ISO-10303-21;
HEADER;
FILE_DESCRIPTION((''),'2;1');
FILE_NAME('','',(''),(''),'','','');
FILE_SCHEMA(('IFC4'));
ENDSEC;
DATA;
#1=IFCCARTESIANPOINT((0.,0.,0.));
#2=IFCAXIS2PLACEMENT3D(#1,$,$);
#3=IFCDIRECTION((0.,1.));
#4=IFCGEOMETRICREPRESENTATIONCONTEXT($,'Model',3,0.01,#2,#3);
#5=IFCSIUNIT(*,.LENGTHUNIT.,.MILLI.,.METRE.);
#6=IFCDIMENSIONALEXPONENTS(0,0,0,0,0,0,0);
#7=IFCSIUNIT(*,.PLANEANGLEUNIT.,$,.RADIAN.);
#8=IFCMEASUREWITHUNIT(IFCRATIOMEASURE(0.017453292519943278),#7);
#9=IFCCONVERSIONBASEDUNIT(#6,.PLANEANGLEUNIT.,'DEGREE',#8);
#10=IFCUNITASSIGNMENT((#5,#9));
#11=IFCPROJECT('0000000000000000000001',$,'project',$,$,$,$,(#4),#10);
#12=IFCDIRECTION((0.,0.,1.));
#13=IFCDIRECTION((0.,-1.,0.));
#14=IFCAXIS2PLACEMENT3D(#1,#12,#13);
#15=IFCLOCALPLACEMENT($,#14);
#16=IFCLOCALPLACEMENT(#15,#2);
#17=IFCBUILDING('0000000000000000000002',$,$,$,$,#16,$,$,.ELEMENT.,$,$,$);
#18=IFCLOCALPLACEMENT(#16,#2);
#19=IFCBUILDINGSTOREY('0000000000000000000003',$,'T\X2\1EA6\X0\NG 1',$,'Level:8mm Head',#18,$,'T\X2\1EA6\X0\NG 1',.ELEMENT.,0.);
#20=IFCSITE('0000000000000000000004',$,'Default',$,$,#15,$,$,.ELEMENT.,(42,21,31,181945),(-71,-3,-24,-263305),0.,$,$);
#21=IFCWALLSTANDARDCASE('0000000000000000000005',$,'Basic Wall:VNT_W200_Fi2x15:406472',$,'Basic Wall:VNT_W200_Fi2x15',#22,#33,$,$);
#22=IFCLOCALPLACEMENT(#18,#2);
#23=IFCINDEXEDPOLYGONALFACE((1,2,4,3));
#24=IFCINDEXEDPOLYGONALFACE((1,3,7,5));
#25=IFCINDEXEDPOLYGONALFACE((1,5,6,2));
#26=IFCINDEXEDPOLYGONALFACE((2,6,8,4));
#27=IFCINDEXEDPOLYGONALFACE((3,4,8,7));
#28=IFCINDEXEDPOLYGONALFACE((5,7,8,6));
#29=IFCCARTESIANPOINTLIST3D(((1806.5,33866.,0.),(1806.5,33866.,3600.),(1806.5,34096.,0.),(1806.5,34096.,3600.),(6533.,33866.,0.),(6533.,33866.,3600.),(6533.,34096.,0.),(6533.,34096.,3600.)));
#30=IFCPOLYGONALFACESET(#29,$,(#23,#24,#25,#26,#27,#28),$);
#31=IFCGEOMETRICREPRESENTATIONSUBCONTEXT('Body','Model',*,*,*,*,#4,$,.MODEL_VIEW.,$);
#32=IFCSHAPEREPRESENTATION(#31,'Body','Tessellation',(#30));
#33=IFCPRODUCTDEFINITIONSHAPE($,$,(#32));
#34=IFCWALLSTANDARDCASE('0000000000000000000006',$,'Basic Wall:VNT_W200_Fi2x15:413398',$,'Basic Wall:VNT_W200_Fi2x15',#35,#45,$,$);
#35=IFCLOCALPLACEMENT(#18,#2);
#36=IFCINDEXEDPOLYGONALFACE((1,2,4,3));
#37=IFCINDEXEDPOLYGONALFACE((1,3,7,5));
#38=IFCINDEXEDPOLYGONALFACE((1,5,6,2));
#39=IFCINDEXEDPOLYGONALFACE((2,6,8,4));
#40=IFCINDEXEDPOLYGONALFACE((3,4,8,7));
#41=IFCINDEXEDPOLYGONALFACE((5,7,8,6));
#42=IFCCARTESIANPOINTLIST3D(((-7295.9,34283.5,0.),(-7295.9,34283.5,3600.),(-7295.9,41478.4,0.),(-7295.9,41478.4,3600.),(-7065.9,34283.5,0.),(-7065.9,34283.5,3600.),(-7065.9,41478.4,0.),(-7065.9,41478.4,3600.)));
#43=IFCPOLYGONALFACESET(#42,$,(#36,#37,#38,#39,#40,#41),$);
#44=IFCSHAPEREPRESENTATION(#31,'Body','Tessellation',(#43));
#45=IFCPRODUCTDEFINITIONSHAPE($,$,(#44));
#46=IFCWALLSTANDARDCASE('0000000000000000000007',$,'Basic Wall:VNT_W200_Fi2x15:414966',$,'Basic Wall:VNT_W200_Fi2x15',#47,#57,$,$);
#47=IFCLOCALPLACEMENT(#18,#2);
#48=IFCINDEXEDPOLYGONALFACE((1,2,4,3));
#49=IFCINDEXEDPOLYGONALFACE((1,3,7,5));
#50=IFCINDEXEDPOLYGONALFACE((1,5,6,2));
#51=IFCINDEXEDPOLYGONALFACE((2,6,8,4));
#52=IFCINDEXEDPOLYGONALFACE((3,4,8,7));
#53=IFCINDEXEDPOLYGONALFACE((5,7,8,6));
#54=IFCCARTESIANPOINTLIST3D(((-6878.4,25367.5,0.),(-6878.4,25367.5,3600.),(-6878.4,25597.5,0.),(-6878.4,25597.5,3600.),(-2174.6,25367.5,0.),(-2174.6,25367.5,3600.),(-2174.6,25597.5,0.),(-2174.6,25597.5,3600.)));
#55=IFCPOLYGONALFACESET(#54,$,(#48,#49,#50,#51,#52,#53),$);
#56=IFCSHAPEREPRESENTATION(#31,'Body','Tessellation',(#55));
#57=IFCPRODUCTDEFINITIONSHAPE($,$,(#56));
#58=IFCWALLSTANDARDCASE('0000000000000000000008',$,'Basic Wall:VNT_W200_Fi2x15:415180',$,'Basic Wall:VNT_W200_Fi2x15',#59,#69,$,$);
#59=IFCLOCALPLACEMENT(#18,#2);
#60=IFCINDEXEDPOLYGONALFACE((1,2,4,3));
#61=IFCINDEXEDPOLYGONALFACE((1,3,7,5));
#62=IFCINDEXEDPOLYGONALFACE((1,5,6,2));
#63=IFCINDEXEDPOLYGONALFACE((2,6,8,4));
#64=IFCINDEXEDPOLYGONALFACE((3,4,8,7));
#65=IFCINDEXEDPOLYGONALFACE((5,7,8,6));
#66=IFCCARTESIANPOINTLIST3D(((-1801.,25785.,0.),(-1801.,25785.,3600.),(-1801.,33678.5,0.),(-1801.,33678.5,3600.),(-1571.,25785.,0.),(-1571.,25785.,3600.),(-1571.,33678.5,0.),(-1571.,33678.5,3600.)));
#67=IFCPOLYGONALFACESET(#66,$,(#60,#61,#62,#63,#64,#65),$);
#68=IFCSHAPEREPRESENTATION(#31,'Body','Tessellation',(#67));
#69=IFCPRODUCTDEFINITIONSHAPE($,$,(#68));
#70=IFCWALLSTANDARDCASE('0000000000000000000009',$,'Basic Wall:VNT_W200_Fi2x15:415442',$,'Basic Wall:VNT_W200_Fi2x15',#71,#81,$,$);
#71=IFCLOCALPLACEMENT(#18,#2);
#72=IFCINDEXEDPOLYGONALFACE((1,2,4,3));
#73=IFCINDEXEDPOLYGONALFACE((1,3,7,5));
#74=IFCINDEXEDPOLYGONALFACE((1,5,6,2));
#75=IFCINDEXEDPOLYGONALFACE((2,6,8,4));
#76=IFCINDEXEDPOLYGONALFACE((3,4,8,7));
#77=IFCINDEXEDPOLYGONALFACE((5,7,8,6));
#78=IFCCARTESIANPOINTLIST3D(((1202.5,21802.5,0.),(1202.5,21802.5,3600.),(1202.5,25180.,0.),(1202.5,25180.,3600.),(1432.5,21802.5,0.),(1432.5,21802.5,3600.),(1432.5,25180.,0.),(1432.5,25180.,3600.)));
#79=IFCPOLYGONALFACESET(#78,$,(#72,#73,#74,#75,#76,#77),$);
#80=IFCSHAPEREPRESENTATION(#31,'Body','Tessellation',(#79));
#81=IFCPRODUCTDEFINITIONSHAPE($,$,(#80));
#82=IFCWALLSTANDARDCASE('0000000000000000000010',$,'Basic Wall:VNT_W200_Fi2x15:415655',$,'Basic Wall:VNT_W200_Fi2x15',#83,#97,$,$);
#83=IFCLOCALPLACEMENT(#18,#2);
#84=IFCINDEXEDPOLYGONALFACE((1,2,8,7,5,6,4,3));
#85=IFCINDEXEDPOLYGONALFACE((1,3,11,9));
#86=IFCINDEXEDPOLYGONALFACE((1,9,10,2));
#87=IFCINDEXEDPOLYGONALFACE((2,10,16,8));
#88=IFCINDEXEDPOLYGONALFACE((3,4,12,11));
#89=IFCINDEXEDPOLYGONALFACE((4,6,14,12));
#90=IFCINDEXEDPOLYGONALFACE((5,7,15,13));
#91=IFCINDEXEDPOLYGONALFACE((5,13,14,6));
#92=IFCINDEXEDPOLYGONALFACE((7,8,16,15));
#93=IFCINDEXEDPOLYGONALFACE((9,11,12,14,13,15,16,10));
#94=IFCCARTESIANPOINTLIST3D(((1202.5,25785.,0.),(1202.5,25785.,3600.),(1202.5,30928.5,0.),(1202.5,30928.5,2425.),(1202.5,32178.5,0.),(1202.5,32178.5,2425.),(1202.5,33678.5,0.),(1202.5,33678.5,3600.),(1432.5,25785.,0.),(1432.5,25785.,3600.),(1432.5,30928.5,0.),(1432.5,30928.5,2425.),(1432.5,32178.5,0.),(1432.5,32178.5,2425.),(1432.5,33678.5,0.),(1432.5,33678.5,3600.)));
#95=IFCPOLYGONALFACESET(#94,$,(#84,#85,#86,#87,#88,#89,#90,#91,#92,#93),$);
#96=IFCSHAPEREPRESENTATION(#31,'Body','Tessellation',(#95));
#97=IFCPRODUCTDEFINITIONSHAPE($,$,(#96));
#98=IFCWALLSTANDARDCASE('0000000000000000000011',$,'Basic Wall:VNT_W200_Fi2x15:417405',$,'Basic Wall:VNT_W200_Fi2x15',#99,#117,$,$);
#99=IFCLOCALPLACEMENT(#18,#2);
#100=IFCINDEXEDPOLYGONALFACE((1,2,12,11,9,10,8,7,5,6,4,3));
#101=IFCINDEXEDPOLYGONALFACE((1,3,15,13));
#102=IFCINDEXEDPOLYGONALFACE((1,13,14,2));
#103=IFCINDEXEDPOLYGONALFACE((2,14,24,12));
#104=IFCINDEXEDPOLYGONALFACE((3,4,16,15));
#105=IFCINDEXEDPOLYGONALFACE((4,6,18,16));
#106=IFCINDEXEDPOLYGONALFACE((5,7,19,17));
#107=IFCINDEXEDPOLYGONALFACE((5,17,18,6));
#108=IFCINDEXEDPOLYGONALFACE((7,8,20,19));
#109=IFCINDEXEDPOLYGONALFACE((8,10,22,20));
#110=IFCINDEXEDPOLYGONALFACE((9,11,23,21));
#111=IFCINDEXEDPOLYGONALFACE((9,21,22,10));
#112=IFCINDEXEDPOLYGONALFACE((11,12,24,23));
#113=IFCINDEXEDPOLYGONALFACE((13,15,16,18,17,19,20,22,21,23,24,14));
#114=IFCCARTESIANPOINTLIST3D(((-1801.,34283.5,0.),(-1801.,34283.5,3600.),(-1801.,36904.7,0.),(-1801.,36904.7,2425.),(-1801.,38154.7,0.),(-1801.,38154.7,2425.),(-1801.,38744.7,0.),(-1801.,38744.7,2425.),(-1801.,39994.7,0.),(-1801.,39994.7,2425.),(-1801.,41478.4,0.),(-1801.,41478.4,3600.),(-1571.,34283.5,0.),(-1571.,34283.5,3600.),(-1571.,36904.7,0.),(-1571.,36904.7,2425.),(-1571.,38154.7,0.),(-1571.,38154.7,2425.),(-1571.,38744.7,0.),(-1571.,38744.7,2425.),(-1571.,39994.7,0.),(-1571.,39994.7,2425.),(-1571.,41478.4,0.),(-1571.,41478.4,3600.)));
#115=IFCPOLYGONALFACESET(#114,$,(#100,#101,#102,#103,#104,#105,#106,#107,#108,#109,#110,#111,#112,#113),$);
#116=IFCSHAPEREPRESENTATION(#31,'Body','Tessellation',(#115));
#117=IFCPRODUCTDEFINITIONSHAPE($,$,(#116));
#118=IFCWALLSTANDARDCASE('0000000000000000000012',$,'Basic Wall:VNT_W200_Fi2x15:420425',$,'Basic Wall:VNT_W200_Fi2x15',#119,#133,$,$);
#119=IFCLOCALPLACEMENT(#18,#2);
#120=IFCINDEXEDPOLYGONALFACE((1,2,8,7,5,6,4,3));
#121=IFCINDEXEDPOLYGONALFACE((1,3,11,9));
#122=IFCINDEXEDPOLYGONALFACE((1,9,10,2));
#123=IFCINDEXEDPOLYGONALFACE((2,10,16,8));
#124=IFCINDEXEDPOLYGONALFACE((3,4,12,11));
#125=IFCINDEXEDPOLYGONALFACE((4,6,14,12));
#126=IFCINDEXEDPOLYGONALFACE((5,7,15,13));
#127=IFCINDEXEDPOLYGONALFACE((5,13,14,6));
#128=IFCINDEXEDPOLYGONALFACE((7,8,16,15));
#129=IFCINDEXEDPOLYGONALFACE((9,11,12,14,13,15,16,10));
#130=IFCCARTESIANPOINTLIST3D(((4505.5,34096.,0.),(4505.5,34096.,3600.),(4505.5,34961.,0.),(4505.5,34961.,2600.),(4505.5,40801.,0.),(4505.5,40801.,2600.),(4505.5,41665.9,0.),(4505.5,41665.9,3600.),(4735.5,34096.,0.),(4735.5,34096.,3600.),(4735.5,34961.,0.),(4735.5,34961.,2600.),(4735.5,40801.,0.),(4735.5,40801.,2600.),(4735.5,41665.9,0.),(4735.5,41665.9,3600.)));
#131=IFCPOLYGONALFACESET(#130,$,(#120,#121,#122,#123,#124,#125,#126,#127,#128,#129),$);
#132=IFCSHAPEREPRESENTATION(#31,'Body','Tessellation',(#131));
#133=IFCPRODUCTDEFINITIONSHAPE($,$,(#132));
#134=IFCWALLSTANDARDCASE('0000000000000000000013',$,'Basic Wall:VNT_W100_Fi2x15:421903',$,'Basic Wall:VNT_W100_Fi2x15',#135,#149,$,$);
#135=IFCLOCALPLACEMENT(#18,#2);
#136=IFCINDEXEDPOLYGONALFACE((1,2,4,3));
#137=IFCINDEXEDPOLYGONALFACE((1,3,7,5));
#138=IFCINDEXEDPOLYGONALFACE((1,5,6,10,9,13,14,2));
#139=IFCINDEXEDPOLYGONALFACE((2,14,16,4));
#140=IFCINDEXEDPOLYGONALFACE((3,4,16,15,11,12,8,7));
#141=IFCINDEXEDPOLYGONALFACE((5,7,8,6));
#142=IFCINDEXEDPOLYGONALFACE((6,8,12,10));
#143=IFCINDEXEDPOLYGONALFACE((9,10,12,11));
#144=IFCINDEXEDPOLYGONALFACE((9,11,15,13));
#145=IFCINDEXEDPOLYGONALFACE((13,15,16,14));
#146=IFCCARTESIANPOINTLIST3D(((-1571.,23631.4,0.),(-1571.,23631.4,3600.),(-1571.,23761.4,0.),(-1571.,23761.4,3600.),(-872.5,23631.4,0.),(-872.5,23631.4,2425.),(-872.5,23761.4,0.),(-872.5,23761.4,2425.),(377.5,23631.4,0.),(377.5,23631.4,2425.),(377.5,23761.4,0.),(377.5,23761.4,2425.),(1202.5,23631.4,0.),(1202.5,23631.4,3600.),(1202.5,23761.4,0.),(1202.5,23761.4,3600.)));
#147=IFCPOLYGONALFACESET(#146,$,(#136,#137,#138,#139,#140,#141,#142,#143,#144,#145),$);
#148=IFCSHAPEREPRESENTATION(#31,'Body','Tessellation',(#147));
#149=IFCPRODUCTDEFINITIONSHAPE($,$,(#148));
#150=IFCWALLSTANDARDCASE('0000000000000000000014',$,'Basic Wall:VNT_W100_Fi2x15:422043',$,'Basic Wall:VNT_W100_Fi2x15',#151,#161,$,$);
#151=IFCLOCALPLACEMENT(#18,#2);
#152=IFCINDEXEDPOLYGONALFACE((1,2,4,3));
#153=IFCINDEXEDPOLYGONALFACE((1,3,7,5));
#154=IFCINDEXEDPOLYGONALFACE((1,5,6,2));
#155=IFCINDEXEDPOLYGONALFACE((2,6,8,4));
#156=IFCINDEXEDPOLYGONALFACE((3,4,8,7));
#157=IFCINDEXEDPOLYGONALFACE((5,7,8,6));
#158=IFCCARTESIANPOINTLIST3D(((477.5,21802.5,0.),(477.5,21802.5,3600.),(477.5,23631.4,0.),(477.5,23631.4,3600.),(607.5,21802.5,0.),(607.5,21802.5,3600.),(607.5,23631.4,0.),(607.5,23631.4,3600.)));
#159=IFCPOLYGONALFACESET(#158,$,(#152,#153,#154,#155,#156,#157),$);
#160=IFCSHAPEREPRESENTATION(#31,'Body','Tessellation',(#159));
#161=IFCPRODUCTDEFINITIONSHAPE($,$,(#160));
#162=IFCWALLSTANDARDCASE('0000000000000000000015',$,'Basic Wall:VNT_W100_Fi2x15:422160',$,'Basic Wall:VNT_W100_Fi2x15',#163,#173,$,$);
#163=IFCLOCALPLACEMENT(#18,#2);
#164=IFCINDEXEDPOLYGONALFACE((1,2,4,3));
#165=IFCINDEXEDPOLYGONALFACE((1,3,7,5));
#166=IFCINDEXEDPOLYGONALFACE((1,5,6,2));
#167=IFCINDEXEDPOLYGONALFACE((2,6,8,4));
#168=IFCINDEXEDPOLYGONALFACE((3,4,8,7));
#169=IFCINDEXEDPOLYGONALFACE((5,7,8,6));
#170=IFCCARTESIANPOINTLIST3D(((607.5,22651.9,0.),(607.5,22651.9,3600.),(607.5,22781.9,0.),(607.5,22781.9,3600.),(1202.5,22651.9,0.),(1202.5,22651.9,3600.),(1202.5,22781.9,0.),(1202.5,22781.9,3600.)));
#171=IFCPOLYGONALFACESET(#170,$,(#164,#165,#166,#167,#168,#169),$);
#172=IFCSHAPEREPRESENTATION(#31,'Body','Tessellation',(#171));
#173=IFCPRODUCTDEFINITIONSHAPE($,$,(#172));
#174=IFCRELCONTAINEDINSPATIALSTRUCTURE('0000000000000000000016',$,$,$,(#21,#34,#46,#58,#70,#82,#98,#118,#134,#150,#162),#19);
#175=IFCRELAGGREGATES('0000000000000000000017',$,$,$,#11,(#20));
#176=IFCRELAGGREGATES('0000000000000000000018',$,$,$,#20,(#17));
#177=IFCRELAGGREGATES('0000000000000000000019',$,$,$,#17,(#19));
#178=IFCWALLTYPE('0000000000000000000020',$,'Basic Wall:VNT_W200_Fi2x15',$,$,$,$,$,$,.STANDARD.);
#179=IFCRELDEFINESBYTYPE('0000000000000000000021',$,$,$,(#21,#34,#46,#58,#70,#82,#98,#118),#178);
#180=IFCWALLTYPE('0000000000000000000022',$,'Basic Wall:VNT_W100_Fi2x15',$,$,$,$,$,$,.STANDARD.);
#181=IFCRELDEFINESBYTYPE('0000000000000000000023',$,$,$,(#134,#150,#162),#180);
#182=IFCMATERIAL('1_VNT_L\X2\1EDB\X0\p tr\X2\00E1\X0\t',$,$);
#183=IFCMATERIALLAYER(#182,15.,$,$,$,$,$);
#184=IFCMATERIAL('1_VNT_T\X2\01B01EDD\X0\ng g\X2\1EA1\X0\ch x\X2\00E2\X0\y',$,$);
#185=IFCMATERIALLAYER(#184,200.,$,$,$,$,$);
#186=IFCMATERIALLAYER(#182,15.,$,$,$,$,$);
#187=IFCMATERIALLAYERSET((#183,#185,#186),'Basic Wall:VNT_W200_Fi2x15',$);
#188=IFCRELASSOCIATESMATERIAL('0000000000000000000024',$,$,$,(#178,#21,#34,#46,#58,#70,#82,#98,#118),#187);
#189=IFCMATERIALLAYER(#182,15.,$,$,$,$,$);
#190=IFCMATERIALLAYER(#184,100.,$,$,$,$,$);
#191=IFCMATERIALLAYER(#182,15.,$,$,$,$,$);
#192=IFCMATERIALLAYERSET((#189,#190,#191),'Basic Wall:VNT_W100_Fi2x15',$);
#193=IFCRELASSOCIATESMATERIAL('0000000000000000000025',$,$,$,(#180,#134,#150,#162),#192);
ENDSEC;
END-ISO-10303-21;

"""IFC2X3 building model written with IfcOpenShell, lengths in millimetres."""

from ifc_helpers import new_model, entity, si_unit, converted_unit, direction, frame, frame_2d, origin, place, context, subcontext, project, spatial, rectangle, extrude, material, layer, layer_set, layer_usage, type_object, element, save


model = new_model("IFC2X3")

# Units and contexts
model_context = context("Model", 3, precision=0.01, world=origin(), true_north=direction((0.0, 1.0)))
body_context = subcontext(model_context, "Body", "Model", "MODEL_VIEW")
ifc_project = project(units=[si_unit("LENGTHUNIT", "METRE", prefix="MILLI"), converted_unit("PLANEANGLEUNIT", "DEGREE", entity("IfcRatioMeasure", 0.017453292519943278), si_unit("PLANEANGLEUNIT", "RADIAN"), dimensions=[0, 0, 0, 0, 0, 0, 0])], contexts=[model_context])

# Site, building, storey
site_placement = place(None, frame((0.0, 0.0, 0.0), z_axis=(0.0, 0.0, 1.0), x_axis=(0.0, -1.0, 0.0)))
site = spatial("IfcSite", under=ifc_project, at=site_placement, Name="Default", CompositionType="ELEMENT", RefLatitude=(42, 21, 31, 181945), RefLongitude=(-71, -3, -24, -263305), RefElevation=0.0)
building_placement = place(site_placement, origin())
building = spatial("IfcBuilding", under=site, at=building_placement, CompositionType="ELEMENT")
storey_placement = place(building_placement, origin())
storey = spatial("IfcBuildingStorey", under=building, at=storey_placement, Name="TẦNG 1", ObjectType="Level:8mm Head", LongName="TẦNG 1", CompositionType="ELEMENT", Elevation=0.0)

# Walls
ifc_material_1 = material(Name="1_VNT_Lớp trát")
ifc_layer_1 = layer(ifc_material_1, 15.0)
ifc_material_2 = material(Name="1_VNT_Tường gạch xây")
ifc_layer_2 = layer(ifc_material_2, 200.0)
ifc_layer_3 = layer(ifc_material_1, 15.0)
ifc_layer_set_1 = layer_set([ifc_layer_1, ifc_layer_2, ifc_layer_3], Name="Basic Wall:VNT_W200_Fi2x15")
ifc_layer_usage_1 = layer_usage(ifc_layer_set_1, "AXIS2", "NEGATIVE", 115.0)
wall_type_1 = type_object("IfcWallType", Name="Basic Wall:VNT_W200_Fi2x15", PredefinedType="STANDARD", material=ifc_layer_set_1)
wall_1_placement = place(storey_placement, frame((6533.0, 33981.0, 0.0), z_axis=(0.0, 0.0, 1.0), x_axis=(-1.0, 0.0, 0.0)))
element("IfcWallStandardCase", 1, at=wall_1_placement, inside=storey, type_object=wall_type_1, material=ifc_layer_usage_1, Name="Basic Wall:VNT_W200_Fi2x15:406472", ObjectType="Basic Wall:VNT_W200_Fi2x15", context=body_context, shape_type="SweptSolid", body=[
    extrude(rectangle(XDim=4726.6, YDim=230.0, at=frame_2d((2363.3, 0.0), x_axis=(-1.0, 0.0))), origin(), (0.0, 0.0, 1.0), 3600.0),
])
wall_2_placement = place(storey_placement, frame((-7180.9, 34283.5, 0.0), z_axis=(0.0, 0.0, 1.0), x_axis=(0.0, 1.0, 0.0)))
element("IfcWallStandardCase", 2, at=wall_2_placement, inside=storey, type_object=wall_type_1, material=ifc_layer_usage_1, Name="Basic Wall:VNT_W200_Fi2x15:413398", ObjectType="Basic Wall:VNT_W200_Fi2x15", context=body_context, shape_type="SweptSolid", body=[
    extrude(rectangle(XDim=7195.0, YDim=230.0, at=frame_2d((3597.5, 0.0), x_axis=(-1.0, 0.0))), origin(), (0.0, 0.0, 1.0), 3600.0),
])
wall_3_placement = place(storey_placement, frame((-6878.4, 25482.5, 0.0)))
element("IfcWallStandardCase", 3, at=wall_3_placement, inside=storey, type_object=wall_type_1, material=ifc_layer_usage_1, Name="Basic Wall:VNT_W200_Fi2x15:414966", ObjectType="Basic Wall:VNT_W200_Fi2x15", context=body_context, shape_type="SweptSolid", body=[
    extrude(rectangle(XDim=4703.8, YDim=230.0, at=frame_2d((2351.9, 0.0), x_axis=(-1.0, 0.0))), origin(), (0.0, 0.0, 1.0), 3600.0),
])
wall_4_placement = place(storey_placement, frame((-1686.0, 25785.0, 0.0), z_axis=(0.0, 0.0, 1.0), x_axis=(0.0, 1.0, 0.0)))
element("IfcWallStandardCase", 4, at=wall_4_placement, inside=storey, type_object=wall_type_1, material=ifc_layer_usage_1, Name="Basic Wall:VNT_W200_Fi2x15:415180", ObjectType="Basic Wall:VNT_W200_Fi2x15", context=body_context, shape_type="SweptSolid", body=[
    extrude(rectangle(XDim=7893.5, YDim=230.0, at=frame_2d((3946.7, 0.0), x_axis=(-1.0, 0.0))), origin(), (0.0, 0.0, 1.0), 3600.0),
])
wall_5_placement = place(storey_placement, frame((1317.5, 21802.5, 0.0), z_axis=(0.0, 0.0, 1.0), x_axis=(0.0, 1.0, 0.0)))
element("IfcWallStandardCase", 5, at=wall_5_placement, inside=storey, type_object=wall_type_1, material=ifc_layer_usage_1, Name="Basic Wall:VNT_W200_Fi2x15:415442", ObjectType="Basic Wall:VNT_W200_Fi2x15", context=body_context, shape_type="SweptSolid", body=[
    extrude(rectangle(XDim=3377.5, YDim=230.0, at=frame_2d((1688.8, 0.0), x_axis=(-1.0, 0.0))), origin(), (0.0, 0.0, 1.0), 3600.0),
])

# Wall, opening
wall_6_placement = place(storey_placement, frame((1317.5, 25785.0, 0.0), z_axis=(0.0, 0.0, 1.0), x_axis=(0.0, 1.0, 0.0)))
wall_6 = element("IfcWallStandardCase", 6, at=wall_6_placement, inside=storey, type_object=wall_type_1, material=ifc_layer_usage_1, Name="Basic Wall:VNT_W200_Fi2x15:415655", ObjectType="Basic Wall:VNT_W200_Fi2x15", context=body_context, shape_type="SweptSolid", body=[
    extrude(rectangle(XDim=7893.5, YDim=230.0, at=frame_2d((3946.7, 0.0), x_axis=(-1.0, 0.0))), origin(), (0.0, 0.0, 1.0), 3600.0),
])
opening_1_placement = place(wall_6_placement, frame((6393.5, 115.0, 0.0)))
element("IfcOpeningElement", 7, at=opening_1_placement, cuts=wall_6, ObjectType="Opening", context=body_context, shape_type="SweptSolid", body=[
    extrude(rectangle(XDim=2425.0, YDim=1250.0, at=frame_2d((1212.5, 625.0), x_axis=(1.0, 0.0))), frame((0.0, 0.0, 0.0), z_axis=(0.0, -1.0, 0.0), x_axis=(0.0, 0.0, 1.0)), (0.0, 0.0, 1.0), 230.0),
])

# Wall, openings
wall_7_placement = place(storey_placement, frame((-1686.0, 34283.5, 0.0), z_axis=(0.0, 0.0, 1.0), x_axis=(0.0, 1.0, 0.0)))
wall_7 = element("IfcWallStandardCase", 8, at=wall_7_placement, inside=storey, type_object=wall_type_1, material=ifc_layer_usage_1, Name="Basic Wall:VNT_W200_Fi2x15:417405", ObjectType="Basic Wall:VNT_W200_Fi2x15", context=body_context, shape_type="SweptSolid", body=[
    extrude(rectangle(XDim=7195.0, YDim=230.0, at=frame_2d((3597.5, 0.0), x_axis=(-1.0, 0.0))), origin(), (0.0, 0.0, 1.0), 3600.0),
])
opening_2_placement = place(wall_7_placement, frame((2621.2, -115.0, 0.0)))
element("IfcOpeningElement", 9, at=opening_2_placement, cuts=wall_7, ObjectType="Opening", context=body_context, shape_type="SweptSolid", body=[
    extrude(rectangle(XDim=2425.0, YDim=1250.0, at=frame_2d((1212.5, 625.0), x_axis=(1.0, 0.0))), frame((0.0, 0.0, 0.0), z_axis=(0.0, 1.0, 0.0), x_axis=(0.0, 0.0, 1.0)), (0.0, 0.0, 1.0), 230.0),
])
opening_3_placement = place(wall_7_placement, frame((4461.2, -115.0, 0.0)))
element("IfcOpeningElement", 10, at=opening_3_placement, cuts=wall_7, ObjectType="Opening", context=body_context, shape_type="SweptSolid", body=[
    extrude(rectangle(XDim=2425.0, YDim=1250.0, at=frame_2d((1212.5, 625.0), x_axis=(1.0, 0.0))), frame((0.0, 0.0, 0.0), z_axis=(0.0, 1.0, 0.0), x_axis=(0.0, 0.0, 1.0)), (0.0, 0.0, 1.0), 230.0),
])

# Walls, openings
wall_8_placement = place(storey_placement, frame((4620.5, 34096.0, 0.0), z_axis=(0.0, 0.0, 1.0), x_axis=(0.0, 1.0, 0.0)))
wall_8 = element("IfcWallStandardCase", 11, at=wall_8_placement, inside=storey, type_object=wall_type_1, material=ifc_layer_usage_1, Name="Basic Wall:VNT_W200_Fi2x15:420425", ObjectType="Basic Wall:VNT_W200_Fi2x15", context=body_context, shape_type="SweptSolid", body=[
    extrude(rectangle(XDim=7570.0, YDim=230.0, at=frame_2d((3785.0, 0.0), x_axis=(1.0, 0.0))), origin(), (0.0, 0.0, 1.0), 3600.0),
])
opening_4_placement = place(wall_8_placement, frame((6705.0, 115.0, 0.0)))
element("IfcOpeningElement", 12, at=opening_4_placement, cuts=wall_8, ObjectType="Opening", context=body_context, shape_type="SweptSolid", body=[
    extrude(rectangle(XDim=2600.0, YDim=5840.0, at=frame_2d((1300.0, 2920.0), x_axis=(1.0, 0.0))), frame((0.0, 0.0, 0.0), z_axis=(0.0, -1.0, 0.0), x_axis=(0.0, 0.0, 1.0)), (0.0, 0.0, 1.0), 230.0),
])
ifc_layer_4 = layer(ifc_material_1, 15.0)
ifc_layer_5 = layer(ifc_material_2, 100.0)
ifc_layer_6 = layer(ifc_material_1, 15.0)
ifc_layer_set_2 = layer_set([ifc_layer_4, ifc_layer_5, ifc_layer_6], Name="Basic Wall:VNT_W100_Fi2x15")
ifc_layer_usage_2 = layer_usage(ifc_layer_set_2, "AXIS2", "NEGATIVE", 65.0)
wall_type_2 = type_object("IfcWallType", Name="Basic Wall:VNT_W100_Fi2x15", PredefinedType="STANDARD", material=ifc_layer_set_2)
wall_9_placement = place(storey_placement, frame((-1571.0, 23696.4, 0.0)))
wall_9 = element("IfcWallStandardCase", 13, at=wall_9_placement, inside=storey, type_object=wall_type_2, material=ifc_layer_usage_2, Name="Basic Wall:VNT_W100_Fi2x15:421903", ObjectType="Basic Wall:VNT_W100_Fi2x15", context=body_context, shape_type="SweptSolid", body=[
    extrude(rectangle(XDim=2773.6, YDim=130.0, at=frame_2d((1386.8, 0.0), x_axis=(1.0, 0.0))), origin(), (0.0, 0.0, 1.0), 3600.0),
])
opening_5_placement = place(wall_9_placement, frame((1948.6, 65.0, 0.0)))
element("IfcOpeningElement", 14, at=opening_5_placement, cuts=wall_9, ObjectType="Opening", context=body_context, shape_type="SweptSolid", body=[
    extrude(rectangle(XDim=2425.0, YDim=1250.0, at=frame_2d((1212.5, 625.0), x_axis=(1.0, 0.0))), frame((0.0, 0.0, 0.0), z_axis=(0.0, -1.0, 0.0), x_axis=(0.0, 0.0, 1.0)), (0.0, 0.0, 1.0), 130.0),
])

# Walls
wall_10_placement = place(storey_placement, frame((542.5, 21802.5, 0.0), z_axis=(0.0, 0.0, 1.0), x_axis=(0.0, 1.0, 0.0)))
element("IfcWallStandardCase", 15, at=wall_10_placement, inside=storey, type_object=wall_type_2, material=ifc_layer_usage_2, Name="Basic Wall:VNT_W100_Fi2x15:422043", ObjectType="Basic Wall:VNT_W100_Fi2x15", context=body_context, shape_type="SweptSolid", body=[
    extrude(rectangle(XDim=1828.9, YDim=130.0, at=frame_2d((914.5, 0.0), x_axis=(-1.0, 0.0))), origin(), (0.0, 0.0, 1.0), 3600.0),
])
wall_11_placement = place(storey_placement, frame((607.5, 22716.9, 0.0)))
element("IfcWallStandardCase", 16, at=wall_11_placement, inside=storey, type_object=wall_type_2, material=ifc_layer_usage_2, Name="Basic Wall:VNT_W100_Fi2x15:422160", ObjectType="Basic Wall:VNT_W100_Fi2x15", context=body_context, shape_type="SweptSolid", body=[
    extrude(rectangle(XDim=595.0, YDim=130.0, at=frame_2d((297.5, 0.0), x_axis=(-1.0, 0.0))), origin(), (0.0, 0.0, 1.0), 3600.0),
])

save(model, "model.ifc")
